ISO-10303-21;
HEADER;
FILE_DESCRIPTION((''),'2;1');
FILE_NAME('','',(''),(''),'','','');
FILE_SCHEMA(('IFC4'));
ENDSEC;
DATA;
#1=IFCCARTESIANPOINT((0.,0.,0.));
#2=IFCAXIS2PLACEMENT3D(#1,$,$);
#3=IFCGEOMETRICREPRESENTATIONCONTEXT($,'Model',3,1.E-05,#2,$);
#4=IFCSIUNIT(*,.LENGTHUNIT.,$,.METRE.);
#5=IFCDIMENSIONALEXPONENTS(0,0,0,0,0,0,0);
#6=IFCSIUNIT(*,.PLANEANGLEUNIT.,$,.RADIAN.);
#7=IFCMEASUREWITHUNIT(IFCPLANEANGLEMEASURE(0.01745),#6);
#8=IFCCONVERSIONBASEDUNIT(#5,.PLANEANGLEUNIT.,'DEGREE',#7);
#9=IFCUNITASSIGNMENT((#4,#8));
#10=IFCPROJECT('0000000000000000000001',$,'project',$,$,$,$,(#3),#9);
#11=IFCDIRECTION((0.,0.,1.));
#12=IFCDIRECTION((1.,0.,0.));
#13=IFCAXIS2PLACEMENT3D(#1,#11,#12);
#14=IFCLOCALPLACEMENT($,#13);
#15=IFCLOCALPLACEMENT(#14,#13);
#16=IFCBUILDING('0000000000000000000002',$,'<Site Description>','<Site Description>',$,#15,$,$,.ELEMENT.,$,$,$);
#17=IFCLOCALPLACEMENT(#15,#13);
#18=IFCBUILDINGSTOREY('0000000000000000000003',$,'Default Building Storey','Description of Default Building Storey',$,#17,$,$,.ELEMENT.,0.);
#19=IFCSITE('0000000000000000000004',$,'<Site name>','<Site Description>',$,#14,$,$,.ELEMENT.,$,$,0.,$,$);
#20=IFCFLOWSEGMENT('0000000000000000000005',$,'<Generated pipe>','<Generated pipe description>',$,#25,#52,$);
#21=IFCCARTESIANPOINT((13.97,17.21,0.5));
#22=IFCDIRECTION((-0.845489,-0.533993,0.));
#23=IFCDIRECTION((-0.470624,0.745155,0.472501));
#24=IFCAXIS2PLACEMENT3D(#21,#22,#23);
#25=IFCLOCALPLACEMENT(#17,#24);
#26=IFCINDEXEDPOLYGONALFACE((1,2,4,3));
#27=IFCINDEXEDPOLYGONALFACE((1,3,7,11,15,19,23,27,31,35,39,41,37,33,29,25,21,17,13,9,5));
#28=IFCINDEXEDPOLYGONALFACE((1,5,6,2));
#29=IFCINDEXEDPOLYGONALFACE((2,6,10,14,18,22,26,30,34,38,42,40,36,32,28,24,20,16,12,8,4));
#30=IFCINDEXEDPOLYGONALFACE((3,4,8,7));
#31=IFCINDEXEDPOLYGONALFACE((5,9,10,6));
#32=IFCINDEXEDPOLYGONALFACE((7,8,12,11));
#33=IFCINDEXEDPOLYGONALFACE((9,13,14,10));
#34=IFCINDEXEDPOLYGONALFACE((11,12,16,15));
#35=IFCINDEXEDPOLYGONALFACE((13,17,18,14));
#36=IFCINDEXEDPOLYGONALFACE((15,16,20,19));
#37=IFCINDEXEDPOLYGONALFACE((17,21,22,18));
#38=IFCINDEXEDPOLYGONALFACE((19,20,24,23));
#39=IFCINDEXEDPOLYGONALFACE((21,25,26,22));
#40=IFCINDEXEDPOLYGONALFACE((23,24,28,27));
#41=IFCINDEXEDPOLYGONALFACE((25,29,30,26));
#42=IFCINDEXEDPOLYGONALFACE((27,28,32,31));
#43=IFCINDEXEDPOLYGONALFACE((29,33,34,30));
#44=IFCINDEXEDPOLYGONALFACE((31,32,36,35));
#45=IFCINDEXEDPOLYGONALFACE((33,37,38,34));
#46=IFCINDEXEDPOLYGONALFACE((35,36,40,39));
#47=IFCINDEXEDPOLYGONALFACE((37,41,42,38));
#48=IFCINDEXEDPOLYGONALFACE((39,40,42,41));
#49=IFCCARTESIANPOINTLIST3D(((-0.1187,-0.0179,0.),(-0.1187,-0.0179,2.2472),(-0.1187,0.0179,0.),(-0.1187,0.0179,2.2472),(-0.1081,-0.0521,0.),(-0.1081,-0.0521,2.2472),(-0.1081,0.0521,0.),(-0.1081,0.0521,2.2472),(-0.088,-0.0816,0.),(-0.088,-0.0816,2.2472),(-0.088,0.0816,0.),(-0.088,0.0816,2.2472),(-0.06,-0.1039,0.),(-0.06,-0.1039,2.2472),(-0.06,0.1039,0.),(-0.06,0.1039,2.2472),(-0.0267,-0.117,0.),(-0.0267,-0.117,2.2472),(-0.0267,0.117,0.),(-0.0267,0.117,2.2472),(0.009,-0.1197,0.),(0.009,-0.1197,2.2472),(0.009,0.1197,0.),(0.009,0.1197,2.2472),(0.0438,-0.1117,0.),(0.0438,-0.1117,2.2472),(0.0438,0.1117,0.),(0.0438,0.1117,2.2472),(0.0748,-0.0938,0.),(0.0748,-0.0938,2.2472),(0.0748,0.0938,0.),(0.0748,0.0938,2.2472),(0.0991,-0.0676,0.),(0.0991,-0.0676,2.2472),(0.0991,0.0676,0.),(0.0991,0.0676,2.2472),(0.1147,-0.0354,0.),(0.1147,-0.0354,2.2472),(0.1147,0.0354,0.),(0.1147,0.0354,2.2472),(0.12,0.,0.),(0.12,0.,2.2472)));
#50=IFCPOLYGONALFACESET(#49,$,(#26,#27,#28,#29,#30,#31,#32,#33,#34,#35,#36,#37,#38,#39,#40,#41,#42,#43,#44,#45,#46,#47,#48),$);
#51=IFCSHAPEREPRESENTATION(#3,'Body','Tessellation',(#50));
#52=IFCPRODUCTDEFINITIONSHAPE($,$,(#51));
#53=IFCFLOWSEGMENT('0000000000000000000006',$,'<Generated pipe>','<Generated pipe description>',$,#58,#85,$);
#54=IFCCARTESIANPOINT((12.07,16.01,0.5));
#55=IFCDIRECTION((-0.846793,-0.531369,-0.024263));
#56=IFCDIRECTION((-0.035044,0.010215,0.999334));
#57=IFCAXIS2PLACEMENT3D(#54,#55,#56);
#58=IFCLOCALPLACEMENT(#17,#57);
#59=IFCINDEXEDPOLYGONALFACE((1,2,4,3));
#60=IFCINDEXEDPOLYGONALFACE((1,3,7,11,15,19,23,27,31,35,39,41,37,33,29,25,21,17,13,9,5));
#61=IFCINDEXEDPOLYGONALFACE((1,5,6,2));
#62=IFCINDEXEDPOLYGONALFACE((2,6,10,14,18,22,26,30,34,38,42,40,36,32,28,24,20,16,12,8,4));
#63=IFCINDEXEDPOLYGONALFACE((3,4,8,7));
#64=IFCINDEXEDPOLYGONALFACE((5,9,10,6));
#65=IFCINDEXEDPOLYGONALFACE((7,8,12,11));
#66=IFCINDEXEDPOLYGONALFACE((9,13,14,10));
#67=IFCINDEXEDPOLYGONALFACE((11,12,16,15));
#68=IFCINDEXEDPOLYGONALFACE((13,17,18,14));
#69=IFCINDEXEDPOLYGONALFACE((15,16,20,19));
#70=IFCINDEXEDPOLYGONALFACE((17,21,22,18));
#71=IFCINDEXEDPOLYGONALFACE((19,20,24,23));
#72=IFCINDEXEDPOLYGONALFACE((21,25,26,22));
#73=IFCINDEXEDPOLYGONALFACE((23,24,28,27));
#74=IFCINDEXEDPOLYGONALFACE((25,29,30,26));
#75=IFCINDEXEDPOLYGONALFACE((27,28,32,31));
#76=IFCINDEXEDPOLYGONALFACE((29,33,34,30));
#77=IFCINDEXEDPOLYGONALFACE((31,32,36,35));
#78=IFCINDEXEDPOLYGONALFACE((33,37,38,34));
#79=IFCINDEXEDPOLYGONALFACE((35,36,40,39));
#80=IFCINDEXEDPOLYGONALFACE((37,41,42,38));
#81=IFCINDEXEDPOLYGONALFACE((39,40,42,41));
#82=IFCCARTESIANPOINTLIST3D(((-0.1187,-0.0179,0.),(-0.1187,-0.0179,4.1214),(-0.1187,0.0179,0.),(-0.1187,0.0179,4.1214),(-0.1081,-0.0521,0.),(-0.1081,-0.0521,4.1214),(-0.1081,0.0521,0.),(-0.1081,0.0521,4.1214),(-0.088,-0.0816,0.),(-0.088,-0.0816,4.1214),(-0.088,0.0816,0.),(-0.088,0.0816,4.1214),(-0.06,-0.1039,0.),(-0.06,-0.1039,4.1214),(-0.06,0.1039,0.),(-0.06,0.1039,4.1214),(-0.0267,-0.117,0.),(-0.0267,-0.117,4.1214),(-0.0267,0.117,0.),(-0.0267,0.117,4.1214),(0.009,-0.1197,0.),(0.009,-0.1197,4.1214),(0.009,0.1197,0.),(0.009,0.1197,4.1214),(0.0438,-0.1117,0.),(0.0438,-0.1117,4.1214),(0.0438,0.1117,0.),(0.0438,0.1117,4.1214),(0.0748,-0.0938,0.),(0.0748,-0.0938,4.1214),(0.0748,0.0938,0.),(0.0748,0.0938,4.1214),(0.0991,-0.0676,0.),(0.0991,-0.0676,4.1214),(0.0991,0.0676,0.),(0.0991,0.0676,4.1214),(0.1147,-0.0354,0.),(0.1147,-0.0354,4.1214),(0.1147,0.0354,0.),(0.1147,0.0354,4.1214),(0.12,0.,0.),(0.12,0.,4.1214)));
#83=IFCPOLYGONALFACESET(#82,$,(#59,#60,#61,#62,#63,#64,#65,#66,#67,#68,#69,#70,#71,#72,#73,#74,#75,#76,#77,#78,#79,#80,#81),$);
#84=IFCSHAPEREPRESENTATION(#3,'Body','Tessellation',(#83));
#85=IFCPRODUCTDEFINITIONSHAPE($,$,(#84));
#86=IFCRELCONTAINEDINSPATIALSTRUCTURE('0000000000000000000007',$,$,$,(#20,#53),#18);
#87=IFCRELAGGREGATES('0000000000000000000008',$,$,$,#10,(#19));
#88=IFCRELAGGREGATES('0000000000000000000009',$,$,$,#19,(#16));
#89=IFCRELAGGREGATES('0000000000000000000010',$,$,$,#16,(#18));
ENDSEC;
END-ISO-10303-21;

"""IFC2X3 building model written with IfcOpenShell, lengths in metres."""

from ifc_helpers import new_model, entity, si_unit, converted_unit, frame, origin, origin_with_axes, origin_2d_with_axis, place, context, project, spatial, circle, extrude, element, save


model = new_model("IFC2X3")

# Units and contexts
model_context = context("Model", 3, precision=1e-05, world=origin())
ifc_project = project(units=[si_unit("LENGTHUNIT", "METRE"), converted_unit("PLANEANGLEUNIT", "DEGREE", entity("IfcPlaneAngleMeasure", 0.01745), si_unit("PLANEANGLEUNIT", "RADIAN"), dimensions=[0, 0, 0, 0, 0, 0, 0])], contexts=[model_context])

# Site, building, storey
site_placement = place(None, origin_with_axes())
site = spatial("IfcSite", under=ifc_project, at=site_placement, Name="<Site name>", Description="<Site Description>", CompositionType="ELEMENT", RefElevation=0.0)
building_placement = place(site_placement, origin_with_axes())
building = spatial("IfcBuilding", under=site, at=building_placement, Name="<Site Description>", Description="<Site Description>", CompositionType="ELEMENT")
storey_placement = place(building_placement, origin_with_axes())
storey = spatial("IfcBuildingStorey", under=building, at=storey_placement, Name="Default Building Storey", Description="Description of Default Building Storey", CompositionType="ELEMENT", Elevation=0.0)

# Flow segments
flow_segment_1_placement = place(storey_placement, frame((13.97, 17.21, 0.5), z_axis=(-0.845489, -0.533993, 0.0), x_axis=(-0.470624, 0.745155, 0.472501)))
element("IfcFlowSegment", 1, at=flow_segment_1_placement, inside=storey, Name="<Generated pipe>", Description="<Generated pipe description>", context=model_context, shape_type="SweptSolid", body=[
    extrude(circle(Radius=0.12, at=origin_2d_with_axis()), origin_with_axes(), (0.0, 0.0, 1.0), 2.2472),
])
flow_segment_2_placement = place(storey_placement, frame((12.07, 16.01, 0.5), z_axis=(-0.846793, -0.531369, -0.024263), x_axis=(-0.035044, 0.010215, 0.999334)))
element("IfcFlowSegment", 2, at=flow_segment_2_placement, inside=storey, Name="<Generated pipe>", Description="<Generated pipe description>", context=model_context, shape_type="SweptSolid", body=[
    extrude(circle(Radius=0.12, at=origin_2d_with_axis()), origin_with_axes(), (0.0, 0.0, 1.0), 4.1214),
])

save(model, "model.ifc")
